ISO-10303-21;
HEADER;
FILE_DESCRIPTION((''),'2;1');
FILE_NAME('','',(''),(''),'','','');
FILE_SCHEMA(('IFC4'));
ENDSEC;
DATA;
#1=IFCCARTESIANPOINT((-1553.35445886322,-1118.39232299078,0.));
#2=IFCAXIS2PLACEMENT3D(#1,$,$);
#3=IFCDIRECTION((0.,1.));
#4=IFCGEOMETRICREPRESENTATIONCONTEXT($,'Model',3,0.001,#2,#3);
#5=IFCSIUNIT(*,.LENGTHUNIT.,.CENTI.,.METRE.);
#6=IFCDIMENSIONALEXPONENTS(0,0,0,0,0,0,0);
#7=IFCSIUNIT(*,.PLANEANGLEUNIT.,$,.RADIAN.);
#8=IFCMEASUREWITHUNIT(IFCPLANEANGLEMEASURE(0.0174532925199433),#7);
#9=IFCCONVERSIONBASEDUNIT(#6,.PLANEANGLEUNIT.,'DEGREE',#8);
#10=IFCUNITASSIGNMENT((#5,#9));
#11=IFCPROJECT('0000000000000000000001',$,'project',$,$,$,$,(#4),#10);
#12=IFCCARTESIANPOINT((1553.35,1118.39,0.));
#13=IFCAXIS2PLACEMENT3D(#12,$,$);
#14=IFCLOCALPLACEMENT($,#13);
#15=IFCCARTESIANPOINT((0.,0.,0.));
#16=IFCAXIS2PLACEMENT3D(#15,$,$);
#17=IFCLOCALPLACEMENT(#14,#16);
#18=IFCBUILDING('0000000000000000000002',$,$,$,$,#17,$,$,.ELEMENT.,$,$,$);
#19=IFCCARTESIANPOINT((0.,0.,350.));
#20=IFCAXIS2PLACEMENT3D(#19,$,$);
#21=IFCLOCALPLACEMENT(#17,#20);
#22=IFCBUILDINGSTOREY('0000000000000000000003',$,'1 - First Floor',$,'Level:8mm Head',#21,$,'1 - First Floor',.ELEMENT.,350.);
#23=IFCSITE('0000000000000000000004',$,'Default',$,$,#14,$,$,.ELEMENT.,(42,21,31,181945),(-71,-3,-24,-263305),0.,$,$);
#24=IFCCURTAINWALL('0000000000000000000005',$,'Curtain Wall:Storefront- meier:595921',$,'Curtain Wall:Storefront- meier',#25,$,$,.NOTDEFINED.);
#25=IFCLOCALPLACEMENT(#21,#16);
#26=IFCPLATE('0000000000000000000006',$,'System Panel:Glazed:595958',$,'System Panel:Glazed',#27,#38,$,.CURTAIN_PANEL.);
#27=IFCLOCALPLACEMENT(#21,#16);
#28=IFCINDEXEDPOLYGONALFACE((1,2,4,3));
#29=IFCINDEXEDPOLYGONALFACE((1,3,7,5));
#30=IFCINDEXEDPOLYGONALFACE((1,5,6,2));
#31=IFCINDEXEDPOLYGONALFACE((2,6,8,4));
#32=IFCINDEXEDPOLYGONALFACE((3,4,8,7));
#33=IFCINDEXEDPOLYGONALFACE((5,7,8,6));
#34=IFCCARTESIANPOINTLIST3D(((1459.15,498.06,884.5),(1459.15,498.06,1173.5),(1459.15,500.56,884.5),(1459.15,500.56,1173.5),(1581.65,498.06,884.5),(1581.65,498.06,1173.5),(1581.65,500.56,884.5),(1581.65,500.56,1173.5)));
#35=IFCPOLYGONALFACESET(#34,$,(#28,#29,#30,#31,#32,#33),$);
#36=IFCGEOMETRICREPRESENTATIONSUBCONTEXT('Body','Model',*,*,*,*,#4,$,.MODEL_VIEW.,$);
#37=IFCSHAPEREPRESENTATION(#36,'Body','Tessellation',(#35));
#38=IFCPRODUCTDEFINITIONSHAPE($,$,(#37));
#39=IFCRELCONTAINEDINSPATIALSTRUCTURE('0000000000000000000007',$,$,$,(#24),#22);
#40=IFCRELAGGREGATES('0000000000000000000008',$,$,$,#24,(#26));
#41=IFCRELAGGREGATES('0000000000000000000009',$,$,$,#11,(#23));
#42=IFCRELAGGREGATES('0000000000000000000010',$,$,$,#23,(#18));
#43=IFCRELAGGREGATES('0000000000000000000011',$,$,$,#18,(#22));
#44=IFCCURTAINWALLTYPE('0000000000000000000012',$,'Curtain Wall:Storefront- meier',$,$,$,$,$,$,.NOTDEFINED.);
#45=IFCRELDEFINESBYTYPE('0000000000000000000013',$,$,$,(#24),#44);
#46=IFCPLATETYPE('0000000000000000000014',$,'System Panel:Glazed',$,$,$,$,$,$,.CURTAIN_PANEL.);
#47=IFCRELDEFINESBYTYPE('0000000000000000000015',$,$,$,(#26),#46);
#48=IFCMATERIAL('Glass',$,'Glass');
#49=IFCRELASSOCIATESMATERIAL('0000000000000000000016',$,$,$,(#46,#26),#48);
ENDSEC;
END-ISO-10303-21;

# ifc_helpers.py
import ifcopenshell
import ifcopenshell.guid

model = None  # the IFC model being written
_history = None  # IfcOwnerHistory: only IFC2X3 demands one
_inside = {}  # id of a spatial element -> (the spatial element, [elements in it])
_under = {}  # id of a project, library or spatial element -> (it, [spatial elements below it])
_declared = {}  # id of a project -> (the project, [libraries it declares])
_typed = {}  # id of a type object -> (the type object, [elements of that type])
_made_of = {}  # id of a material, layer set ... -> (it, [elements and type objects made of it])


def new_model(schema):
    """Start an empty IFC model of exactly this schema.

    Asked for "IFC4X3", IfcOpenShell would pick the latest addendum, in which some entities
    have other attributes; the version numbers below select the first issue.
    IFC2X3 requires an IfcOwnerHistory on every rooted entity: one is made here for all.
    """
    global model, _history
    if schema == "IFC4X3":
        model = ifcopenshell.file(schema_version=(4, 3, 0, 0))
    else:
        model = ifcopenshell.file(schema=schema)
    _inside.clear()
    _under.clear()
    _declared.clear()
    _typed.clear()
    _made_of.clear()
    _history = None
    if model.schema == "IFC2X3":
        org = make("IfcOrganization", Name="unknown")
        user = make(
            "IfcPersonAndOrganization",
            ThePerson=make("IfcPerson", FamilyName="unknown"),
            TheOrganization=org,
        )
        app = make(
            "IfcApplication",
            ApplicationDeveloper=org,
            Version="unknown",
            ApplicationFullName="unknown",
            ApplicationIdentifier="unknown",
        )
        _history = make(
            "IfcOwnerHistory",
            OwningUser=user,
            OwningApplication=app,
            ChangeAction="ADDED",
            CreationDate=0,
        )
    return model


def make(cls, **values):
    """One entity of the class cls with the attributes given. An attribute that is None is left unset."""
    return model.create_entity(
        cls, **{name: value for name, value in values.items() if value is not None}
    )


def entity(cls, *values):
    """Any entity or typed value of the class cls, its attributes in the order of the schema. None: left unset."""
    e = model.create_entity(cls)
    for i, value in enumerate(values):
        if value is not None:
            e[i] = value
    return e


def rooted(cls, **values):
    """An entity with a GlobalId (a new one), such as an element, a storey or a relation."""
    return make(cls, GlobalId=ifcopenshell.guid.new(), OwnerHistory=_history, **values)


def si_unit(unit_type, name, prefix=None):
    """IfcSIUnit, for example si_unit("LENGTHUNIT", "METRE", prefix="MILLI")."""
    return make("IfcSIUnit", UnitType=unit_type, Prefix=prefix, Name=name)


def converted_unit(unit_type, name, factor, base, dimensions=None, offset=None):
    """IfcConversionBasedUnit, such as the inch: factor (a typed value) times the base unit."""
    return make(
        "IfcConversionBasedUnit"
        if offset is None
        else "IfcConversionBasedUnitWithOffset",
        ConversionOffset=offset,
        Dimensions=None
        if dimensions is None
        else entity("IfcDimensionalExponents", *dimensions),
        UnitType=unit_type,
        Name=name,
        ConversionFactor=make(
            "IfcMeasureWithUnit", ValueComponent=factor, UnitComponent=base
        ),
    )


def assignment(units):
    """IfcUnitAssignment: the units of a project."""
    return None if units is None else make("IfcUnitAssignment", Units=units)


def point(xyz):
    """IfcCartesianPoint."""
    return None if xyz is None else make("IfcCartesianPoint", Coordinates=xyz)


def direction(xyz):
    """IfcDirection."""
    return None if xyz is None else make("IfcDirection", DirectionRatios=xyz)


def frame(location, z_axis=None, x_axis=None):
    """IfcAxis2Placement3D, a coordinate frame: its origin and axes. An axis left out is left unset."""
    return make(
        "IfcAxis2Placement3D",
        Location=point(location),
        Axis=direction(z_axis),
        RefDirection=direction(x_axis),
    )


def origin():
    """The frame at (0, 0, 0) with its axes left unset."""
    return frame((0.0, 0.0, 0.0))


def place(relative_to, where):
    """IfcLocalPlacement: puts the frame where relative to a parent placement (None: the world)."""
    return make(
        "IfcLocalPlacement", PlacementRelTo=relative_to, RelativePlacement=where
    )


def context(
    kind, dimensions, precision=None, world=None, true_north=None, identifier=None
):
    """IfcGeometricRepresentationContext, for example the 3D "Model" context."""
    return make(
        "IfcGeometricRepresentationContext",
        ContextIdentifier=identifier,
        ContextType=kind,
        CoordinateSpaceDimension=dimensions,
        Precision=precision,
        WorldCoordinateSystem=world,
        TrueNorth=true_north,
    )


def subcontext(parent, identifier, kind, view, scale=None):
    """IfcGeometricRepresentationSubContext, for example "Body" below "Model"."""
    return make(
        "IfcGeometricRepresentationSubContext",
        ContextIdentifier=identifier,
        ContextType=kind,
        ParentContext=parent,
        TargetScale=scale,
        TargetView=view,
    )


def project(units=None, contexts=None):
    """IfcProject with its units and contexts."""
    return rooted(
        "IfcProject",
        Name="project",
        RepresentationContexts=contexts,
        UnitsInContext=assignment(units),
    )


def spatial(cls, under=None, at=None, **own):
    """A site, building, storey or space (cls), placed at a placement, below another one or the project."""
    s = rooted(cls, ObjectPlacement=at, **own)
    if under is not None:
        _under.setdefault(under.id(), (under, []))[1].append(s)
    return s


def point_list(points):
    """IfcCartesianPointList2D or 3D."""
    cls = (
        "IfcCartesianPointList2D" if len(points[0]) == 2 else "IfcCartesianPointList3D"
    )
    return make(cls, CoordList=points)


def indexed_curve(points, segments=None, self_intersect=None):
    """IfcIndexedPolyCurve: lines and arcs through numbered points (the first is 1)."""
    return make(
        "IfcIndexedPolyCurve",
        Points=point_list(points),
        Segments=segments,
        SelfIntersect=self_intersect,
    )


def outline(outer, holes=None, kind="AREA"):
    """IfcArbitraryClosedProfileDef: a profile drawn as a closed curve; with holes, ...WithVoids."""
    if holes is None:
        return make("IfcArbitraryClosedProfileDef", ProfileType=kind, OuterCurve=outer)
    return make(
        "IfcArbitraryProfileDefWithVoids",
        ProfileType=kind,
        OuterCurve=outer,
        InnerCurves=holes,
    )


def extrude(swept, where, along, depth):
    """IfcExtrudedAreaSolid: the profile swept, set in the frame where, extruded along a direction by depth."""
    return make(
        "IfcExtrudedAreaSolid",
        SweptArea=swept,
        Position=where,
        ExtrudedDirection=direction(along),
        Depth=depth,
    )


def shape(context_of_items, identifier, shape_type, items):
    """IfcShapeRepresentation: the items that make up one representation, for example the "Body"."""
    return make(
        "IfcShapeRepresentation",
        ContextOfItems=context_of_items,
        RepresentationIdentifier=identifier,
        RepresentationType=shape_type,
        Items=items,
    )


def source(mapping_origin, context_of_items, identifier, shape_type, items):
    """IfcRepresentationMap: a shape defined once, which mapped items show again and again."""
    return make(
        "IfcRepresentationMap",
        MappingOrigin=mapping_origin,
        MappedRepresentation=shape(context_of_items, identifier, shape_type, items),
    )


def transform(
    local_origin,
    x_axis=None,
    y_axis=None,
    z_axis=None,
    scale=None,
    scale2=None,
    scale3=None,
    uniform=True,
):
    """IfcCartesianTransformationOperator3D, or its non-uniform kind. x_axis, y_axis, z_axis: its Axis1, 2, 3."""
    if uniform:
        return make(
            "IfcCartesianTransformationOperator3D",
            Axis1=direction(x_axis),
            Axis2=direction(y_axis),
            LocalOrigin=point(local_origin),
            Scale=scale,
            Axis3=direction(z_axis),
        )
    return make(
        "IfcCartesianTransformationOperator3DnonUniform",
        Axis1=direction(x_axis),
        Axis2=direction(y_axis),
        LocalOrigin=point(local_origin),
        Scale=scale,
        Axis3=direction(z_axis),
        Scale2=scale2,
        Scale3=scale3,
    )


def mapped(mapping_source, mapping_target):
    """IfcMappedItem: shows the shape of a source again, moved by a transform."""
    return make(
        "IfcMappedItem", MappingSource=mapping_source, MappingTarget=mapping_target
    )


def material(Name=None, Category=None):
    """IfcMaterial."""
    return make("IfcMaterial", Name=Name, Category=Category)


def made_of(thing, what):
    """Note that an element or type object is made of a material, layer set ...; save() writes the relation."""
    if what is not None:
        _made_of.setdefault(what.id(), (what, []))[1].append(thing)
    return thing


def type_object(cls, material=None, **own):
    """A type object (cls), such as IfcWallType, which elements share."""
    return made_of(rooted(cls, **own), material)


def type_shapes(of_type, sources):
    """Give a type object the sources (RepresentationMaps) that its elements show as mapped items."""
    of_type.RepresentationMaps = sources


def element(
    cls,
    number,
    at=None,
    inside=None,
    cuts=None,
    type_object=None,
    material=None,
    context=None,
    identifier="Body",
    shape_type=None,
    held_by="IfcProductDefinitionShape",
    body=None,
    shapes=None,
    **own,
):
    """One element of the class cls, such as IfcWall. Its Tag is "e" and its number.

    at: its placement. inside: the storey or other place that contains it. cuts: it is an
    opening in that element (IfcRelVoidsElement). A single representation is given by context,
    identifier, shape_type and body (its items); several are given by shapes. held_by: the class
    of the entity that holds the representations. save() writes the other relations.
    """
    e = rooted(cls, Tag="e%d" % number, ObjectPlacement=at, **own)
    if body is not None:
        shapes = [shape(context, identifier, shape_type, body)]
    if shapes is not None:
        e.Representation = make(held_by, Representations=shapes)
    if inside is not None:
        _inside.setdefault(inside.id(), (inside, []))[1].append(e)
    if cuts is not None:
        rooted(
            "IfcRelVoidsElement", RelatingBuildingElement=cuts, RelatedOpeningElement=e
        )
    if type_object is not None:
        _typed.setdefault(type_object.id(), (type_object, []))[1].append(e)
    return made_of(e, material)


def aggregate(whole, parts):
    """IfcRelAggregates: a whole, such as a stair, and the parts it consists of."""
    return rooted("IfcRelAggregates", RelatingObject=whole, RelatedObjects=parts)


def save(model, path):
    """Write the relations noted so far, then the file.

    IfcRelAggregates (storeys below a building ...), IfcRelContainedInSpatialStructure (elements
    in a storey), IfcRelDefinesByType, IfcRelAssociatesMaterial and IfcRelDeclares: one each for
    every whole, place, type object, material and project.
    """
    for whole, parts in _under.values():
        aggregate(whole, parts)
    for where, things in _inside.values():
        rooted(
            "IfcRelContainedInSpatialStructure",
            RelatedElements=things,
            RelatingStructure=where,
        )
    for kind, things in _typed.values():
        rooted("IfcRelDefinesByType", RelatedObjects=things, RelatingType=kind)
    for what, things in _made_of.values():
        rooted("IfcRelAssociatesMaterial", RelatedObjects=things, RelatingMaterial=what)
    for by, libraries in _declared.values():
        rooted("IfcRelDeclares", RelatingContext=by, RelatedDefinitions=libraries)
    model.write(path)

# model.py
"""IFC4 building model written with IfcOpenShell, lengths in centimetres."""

from ifc_helpers import new_model, entity, si_unit, converted_unit, direction, frame, origin, place, context, subcontext, project, spatial, indexed_curve, outline, extrude, source, transform, mapped, material, type_object, type_shapes, element, aggregate, save


model = new_model("IFC4")

# Units and contexts
model_context = context("Model", 3, precision=0.001, world=frame((-1553.35445886322, -1118.39232299078, 0.0)), true_north=direction((0.0, 1.0)))
body_context = subcontext(model_context, "Body", "Model", "MODEL_VIEW")
ifc_project = project(units=[si_unit("LENGTHUNIT", "METRE", prefix="CENTI"), converted_unit("PLANEANGLEUNIT", "DEGREE", entity("IfcPlaneAngleMeasure", 0.0174532925199433), si_unit("PLANEANGLEUNIT", "RADIAN"), dimensions=[0, 0, 0, 0, 0, 0, 0])], contexts=[model_context])

# Site, building, storey
site_placement = place(None, frame((1553.35, 1118.39, 0.0)))
site = spatial("IfcSite", under=ifc_project, at=site_placement, Name="Default", CompositionType="ELEMENT", RefLatitude=(42, 21, 31, 181945), RefLongitude=(-71, -3, -24, -263305), RefElevation=0.0)
building_placement = place(site_placement, origin())
building = spatial("IfcBuilding", under=site, at=building_placement, CompositionType="ELEMENT")
storey_placement = place(building_placement, frame((0.0, 0.0, 350.0)))
storey = spatial("IfcBuildingStorey", under=building, at=storey_placement, Name="1 - First Floor", ObjectType="Level:8mm Head", LongName="1 - First Floor", CompositionType="ELEMENT", Elevation=350.0)

# Curtain wall, plate
curtain_wall_type = type_object("IfcCurtainWallType", Name="Curtain Wall:Storefront- meier", PredefinedType="NOTDEFINED")
curtain_wall_placement = place(storey_placement, frame((0.0, 0.0, -350.0)))
curtain_wall = element("IfcCurtainWall", 1, at=curtain_wall_placement, inside=storey, type_object=curtain_wall_type, Name="Curtain Wall:Storefront- meier:595921", ObjectType="Curtain Wall:Storefront- meier", PredefinedType="NOTDEFINED")
ifc_material_1 = material(Name="Glass", Category="Glass")
plate_type_1 = type_object("IfcPlateType", Name="System Panel:Glazed", PredefinedType="CURTAIN_PANEL", material=ifc_material_1)
shared_shape_1 = source(origin(), body_context, "Body", "SweptSolid", [
    extrude(outline(indexed_curve([(-1.25, -61.25), (1.25, -61.25), (1.25, 61.25), (-1.25, 61.25), (-1.25, -61.25)], self_intersect=False)), frame((0.0, 3.7, 0.0), z_axis=(0.0, 0.0, 1.0), x_axis=(0.0, 1.0, 0.0)), (0.0, 0.0, 1.0), 289.0),
])
type_shapes(plate_type_1, [shared_shape_1])
plate_1_placement = place(curtain_wall_placement, frame((1520.4, 495.61, 1234.5)))
plate_1 = element("IfcPlate", 2, at=plate_1_placement, type_object=plate_type_1, material=ifc_material_1, Name="System Panel:Glazed:595958", ObjectType="System Panel:Glazed", PredefinedType="CURTAIN_PANEL", context=body_context, shape_type="MappedRepresentation", body=[
    mapped(shared_shape_1, transform((0.0, 0.0, 0.0), scale=1.0)),
])
aggregate(curtain_wall, [plate_1])

save(model, "model.ifc")
